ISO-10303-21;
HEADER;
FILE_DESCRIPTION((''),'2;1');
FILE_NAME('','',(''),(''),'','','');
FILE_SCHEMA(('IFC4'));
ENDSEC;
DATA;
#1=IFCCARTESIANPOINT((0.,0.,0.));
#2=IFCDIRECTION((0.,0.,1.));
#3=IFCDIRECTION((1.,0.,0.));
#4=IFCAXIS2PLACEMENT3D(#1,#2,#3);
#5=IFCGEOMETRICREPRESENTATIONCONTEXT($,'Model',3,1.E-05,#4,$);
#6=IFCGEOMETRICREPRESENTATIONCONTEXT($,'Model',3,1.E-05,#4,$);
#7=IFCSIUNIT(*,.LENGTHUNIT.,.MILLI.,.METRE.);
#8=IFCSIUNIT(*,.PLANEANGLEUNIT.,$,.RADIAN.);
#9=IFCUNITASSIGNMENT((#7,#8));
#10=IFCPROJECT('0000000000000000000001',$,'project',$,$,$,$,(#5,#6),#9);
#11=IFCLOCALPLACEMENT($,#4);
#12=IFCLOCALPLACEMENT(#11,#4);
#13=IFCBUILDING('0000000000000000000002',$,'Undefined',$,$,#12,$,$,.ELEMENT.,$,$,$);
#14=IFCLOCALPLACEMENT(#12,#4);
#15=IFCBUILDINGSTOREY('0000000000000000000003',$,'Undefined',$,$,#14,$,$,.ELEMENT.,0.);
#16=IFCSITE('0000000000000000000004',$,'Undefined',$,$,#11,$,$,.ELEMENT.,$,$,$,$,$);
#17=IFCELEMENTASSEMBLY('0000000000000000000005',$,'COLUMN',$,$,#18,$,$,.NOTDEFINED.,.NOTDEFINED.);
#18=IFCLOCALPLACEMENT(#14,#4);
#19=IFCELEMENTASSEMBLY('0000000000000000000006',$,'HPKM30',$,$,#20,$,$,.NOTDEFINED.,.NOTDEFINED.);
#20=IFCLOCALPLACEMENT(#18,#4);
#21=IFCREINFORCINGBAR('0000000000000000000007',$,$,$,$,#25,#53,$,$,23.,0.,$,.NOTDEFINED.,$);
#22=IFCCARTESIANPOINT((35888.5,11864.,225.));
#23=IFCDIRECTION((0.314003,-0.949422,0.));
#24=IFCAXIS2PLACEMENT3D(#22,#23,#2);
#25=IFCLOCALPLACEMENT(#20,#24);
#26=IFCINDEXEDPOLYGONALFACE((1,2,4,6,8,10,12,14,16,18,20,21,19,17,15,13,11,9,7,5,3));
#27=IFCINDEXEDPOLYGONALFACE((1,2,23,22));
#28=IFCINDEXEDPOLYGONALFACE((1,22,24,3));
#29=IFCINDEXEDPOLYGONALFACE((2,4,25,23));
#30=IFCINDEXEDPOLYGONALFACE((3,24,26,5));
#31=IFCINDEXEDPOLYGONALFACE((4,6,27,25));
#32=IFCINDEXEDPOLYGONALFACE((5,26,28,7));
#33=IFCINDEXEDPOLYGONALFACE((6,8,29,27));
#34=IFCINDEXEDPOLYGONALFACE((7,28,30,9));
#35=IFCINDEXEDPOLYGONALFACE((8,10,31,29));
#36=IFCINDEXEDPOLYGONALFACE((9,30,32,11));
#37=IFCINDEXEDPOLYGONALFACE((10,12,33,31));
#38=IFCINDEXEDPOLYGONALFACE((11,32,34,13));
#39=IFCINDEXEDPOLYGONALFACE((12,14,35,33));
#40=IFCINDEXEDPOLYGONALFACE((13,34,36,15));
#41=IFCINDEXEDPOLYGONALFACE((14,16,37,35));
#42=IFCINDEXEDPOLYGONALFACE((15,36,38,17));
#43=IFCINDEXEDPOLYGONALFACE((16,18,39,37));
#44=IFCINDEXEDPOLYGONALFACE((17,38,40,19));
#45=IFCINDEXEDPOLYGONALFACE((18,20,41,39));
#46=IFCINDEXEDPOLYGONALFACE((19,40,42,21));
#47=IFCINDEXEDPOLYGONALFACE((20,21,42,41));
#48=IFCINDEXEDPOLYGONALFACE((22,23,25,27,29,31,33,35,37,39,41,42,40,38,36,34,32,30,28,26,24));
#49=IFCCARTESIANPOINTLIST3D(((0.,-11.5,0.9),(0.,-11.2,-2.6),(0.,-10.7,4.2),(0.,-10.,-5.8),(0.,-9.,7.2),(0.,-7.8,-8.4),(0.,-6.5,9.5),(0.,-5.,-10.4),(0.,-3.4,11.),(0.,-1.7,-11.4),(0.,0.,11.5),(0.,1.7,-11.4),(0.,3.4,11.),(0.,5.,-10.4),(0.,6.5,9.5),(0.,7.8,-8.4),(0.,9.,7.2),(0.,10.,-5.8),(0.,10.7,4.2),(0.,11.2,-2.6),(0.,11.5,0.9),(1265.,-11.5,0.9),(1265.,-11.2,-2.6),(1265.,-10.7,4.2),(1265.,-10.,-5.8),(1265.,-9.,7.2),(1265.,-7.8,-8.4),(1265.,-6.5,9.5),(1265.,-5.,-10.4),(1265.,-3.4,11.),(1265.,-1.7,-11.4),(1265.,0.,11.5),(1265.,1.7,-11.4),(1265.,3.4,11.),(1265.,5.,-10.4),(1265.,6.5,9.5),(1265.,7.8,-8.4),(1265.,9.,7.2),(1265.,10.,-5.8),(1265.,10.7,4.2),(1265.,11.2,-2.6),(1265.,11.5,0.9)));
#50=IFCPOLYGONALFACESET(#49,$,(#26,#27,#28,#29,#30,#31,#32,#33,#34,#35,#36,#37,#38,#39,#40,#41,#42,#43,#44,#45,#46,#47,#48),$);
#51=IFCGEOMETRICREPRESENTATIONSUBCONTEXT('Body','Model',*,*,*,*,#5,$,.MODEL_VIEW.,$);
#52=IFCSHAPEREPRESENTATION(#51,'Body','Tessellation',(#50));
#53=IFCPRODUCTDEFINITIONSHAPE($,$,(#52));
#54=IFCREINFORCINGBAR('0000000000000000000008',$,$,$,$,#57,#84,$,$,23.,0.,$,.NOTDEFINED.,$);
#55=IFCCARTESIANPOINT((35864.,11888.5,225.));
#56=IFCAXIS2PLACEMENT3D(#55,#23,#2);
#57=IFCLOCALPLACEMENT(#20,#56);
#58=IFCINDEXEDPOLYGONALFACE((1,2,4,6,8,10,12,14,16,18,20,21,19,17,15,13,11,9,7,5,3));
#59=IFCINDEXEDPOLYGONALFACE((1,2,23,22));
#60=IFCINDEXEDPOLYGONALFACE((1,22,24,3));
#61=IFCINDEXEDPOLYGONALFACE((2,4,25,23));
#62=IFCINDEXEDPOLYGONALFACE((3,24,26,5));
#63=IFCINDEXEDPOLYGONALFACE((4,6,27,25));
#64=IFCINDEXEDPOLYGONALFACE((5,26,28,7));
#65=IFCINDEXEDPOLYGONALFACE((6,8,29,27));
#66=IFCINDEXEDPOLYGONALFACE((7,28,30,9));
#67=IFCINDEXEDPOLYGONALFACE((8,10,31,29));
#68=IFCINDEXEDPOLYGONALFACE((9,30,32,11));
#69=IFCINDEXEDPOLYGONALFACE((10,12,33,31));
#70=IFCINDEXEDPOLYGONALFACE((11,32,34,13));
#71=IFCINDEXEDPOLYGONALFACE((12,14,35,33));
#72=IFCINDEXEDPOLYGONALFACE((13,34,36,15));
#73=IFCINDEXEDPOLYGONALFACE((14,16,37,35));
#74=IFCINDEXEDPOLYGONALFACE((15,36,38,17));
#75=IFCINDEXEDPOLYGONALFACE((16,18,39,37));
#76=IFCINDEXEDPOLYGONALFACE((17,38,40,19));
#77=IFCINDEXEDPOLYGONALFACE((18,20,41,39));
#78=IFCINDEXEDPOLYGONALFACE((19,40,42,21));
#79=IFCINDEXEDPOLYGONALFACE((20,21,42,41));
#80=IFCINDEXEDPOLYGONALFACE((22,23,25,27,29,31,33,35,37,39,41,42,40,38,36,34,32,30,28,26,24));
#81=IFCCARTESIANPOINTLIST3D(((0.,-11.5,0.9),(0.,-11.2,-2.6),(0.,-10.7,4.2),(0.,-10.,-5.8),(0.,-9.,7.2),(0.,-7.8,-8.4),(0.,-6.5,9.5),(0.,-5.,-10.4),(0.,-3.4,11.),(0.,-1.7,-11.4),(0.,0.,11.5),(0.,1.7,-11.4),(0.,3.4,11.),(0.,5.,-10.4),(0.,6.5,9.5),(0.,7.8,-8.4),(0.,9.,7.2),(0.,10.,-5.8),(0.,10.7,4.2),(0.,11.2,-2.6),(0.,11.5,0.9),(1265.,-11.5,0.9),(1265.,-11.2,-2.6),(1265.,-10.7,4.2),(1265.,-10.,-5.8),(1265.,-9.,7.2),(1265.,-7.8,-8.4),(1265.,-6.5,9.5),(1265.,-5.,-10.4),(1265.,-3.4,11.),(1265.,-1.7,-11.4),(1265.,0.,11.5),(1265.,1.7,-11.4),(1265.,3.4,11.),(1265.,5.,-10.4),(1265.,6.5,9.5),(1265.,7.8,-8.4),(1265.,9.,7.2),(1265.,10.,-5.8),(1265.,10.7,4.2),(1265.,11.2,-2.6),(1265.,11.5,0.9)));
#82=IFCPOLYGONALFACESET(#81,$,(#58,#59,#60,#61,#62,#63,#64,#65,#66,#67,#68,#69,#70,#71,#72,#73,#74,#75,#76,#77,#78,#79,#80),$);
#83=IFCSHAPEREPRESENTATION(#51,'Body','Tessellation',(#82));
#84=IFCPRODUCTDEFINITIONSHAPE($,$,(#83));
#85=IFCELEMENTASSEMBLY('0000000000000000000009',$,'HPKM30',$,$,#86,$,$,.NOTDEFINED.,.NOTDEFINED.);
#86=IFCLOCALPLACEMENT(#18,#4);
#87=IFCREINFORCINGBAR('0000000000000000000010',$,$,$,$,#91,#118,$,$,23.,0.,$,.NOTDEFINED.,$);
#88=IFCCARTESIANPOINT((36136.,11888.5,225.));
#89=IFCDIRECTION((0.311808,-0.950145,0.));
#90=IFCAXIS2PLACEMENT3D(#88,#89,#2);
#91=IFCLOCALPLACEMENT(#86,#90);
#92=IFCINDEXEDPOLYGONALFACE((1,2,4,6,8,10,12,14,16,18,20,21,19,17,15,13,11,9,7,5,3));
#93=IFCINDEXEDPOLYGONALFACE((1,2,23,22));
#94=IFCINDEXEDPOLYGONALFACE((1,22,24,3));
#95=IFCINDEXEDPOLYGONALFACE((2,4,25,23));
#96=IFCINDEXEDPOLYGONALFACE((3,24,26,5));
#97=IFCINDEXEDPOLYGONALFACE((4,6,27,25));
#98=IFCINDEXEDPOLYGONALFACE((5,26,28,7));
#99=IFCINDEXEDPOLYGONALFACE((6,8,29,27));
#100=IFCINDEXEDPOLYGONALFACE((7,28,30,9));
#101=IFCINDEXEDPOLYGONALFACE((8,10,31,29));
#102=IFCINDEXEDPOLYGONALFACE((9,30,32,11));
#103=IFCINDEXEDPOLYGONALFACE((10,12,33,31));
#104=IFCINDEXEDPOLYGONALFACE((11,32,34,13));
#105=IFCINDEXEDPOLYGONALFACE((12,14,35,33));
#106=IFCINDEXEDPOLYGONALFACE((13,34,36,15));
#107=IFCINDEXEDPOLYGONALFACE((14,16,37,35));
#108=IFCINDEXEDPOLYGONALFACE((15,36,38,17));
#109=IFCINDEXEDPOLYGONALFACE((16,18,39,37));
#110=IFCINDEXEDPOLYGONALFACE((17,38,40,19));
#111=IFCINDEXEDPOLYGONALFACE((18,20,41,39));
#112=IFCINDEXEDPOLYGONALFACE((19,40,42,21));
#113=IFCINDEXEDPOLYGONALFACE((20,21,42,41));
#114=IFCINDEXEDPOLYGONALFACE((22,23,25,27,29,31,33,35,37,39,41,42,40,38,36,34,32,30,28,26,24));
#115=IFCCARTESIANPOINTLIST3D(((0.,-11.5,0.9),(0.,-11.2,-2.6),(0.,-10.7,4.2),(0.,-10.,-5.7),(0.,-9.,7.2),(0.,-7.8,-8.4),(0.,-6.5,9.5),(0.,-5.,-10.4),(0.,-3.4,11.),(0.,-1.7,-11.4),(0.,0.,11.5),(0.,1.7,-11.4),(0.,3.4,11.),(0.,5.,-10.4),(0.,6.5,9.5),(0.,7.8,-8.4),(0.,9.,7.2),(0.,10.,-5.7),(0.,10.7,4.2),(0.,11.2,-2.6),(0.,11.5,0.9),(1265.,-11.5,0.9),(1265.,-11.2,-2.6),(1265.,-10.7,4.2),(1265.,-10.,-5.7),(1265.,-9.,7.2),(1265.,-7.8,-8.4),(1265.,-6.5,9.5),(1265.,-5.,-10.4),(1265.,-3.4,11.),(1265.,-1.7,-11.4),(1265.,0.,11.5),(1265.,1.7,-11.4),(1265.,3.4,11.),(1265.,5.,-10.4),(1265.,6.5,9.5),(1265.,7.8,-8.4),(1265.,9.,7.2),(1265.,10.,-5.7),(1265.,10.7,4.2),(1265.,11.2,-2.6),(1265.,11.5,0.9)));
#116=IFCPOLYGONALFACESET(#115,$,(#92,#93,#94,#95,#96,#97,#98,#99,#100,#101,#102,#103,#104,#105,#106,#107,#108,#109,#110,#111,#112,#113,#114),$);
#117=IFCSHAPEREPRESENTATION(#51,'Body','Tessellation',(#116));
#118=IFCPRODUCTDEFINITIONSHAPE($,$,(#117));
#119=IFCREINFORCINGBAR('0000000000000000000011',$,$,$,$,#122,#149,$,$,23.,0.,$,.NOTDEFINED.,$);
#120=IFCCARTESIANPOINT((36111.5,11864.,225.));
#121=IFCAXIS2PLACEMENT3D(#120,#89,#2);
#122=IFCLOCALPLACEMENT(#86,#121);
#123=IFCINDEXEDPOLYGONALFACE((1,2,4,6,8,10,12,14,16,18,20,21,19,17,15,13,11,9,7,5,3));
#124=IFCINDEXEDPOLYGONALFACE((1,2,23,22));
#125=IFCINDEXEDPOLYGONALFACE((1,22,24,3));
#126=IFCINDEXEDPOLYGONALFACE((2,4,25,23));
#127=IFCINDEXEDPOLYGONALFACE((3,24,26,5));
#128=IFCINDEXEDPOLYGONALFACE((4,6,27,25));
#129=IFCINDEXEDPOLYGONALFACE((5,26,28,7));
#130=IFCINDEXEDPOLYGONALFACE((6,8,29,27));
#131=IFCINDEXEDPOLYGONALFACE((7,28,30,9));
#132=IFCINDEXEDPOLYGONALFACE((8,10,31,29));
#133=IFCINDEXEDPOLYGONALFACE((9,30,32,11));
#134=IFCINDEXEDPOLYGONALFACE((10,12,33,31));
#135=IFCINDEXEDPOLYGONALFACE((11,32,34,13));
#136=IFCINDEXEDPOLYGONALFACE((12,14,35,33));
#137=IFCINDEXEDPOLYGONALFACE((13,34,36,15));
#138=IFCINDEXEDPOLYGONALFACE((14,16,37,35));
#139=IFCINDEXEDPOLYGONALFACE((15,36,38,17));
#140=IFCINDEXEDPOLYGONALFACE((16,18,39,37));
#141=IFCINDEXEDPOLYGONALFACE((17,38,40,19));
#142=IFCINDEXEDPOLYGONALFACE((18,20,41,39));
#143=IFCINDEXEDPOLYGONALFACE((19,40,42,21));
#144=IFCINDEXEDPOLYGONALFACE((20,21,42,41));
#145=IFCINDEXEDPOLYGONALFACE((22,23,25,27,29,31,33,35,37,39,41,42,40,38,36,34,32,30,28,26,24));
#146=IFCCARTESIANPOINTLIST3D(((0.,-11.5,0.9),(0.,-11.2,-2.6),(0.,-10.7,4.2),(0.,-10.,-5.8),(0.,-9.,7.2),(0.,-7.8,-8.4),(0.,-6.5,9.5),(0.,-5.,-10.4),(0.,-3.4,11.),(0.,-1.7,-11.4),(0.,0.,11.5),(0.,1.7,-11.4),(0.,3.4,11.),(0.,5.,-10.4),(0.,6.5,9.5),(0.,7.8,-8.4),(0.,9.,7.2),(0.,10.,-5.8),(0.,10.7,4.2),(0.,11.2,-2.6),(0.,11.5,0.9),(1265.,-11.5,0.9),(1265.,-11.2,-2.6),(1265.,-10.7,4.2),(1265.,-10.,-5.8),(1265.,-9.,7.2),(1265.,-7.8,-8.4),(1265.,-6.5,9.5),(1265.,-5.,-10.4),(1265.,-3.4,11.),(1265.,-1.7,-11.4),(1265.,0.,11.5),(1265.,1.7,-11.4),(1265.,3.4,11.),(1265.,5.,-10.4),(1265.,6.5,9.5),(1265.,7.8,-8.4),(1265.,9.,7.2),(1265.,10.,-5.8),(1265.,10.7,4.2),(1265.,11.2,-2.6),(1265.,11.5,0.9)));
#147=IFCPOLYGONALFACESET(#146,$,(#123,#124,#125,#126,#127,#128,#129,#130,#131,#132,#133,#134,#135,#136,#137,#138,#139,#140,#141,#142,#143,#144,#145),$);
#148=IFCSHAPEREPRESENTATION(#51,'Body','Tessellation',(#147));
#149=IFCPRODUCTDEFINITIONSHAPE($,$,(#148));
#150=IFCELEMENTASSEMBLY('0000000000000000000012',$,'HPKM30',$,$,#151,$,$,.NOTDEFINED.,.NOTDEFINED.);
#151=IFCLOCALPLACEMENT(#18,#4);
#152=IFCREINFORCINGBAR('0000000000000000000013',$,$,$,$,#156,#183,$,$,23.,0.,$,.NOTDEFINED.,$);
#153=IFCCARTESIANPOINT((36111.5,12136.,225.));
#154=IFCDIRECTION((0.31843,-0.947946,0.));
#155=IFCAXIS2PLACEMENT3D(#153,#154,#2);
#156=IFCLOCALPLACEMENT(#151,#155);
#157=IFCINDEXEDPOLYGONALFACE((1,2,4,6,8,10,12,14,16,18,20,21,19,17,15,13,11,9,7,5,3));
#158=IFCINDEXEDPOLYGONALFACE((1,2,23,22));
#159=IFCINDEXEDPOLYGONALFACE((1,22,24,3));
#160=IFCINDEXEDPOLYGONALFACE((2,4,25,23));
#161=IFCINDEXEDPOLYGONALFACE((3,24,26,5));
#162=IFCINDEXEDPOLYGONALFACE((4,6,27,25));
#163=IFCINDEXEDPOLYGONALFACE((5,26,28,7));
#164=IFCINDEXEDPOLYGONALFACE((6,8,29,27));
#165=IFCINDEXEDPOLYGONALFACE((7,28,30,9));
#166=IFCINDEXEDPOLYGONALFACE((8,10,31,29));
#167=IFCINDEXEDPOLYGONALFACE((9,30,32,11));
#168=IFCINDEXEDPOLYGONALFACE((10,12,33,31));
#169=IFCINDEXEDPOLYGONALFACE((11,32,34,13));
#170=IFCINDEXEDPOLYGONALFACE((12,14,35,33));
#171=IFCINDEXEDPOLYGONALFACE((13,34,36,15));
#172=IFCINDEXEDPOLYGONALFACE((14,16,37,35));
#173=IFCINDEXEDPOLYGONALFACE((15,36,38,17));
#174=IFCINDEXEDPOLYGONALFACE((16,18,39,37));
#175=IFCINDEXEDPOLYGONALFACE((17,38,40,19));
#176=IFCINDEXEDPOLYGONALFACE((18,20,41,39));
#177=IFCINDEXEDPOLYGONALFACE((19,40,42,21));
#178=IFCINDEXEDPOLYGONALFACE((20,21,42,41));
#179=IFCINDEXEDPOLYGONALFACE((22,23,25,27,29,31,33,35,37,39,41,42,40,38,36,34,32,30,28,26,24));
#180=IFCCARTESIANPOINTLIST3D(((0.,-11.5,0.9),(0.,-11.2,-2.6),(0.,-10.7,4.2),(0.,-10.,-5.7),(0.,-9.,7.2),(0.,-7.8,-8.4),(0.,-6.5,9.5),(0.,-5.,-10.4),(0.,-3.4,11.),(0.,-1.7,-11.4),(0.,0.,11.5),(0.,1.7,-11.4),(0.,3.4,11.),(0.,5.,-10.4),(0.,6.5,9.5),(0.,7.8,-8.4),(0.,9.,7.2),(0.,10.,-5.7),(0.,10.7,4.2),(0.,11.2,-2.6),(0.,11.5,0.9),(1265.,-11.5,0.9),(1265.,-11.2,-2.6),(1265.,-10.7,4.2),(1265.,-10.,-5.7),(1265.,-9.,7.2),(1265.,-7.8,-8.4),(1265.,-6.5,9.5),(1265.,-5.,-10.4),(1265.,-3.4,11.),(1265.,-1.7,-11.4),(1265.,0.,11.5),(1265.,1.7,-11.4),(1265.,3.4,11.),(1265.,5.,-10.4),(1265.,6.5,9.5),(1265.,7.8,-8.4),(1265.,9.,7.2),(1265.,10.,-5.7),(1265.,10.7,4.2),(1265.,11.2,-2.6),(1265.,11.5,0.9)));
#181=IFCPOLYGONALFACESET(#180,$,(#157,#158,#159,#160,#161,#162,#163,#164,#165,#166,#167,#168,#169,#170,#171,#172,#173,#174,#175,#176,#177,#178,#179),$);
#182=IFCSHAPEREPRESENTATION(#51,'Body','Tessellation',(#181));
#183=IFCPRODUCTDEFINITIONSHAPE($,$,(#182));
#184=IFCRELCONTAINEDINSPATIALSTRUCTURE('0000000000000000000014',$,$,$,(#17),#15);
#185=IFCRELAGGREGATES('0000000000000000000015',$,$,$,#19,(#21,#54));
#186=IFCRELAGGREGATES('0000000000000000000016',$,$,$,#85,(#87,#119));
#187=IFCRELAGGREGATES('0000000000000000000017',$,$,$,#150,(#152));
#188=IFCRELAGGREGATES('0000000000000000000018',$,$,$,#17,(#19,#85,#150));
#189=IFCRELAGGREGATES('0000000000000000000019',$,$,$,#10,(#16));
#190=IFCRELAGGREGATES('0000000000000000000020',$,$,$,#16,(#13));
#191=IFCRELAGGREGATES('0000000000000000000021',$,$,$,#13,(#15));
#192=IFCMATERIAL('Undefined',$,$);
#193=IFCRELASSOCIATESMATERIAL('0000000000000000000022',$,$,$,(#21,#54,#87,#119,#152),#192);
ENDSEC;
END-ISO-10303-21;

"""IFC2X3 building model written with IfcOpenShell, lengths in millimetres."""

from ifc_helpers import new_model, entity, si_unit, frame, origin_with_axes, place, context, subcontext, project, spatial, source, transform, mapped, material, element, aggregate, save


model = new_model("IFC2X3")

# Units and contexts
model_context_1 = context("Model", 3, precision=1e-05, world=origin_with_axes())
model_context_2 = context("Model", 3, precision=1e-05, world=origin_with_axes())
body_context = subcontext(model_context_1, "Body", "Model", "MODEL_VIEW")
ifc_project = project(units=[si_unit("LENGTHUNIT", "METRE", prefix="MILLI"), si_unit("PLANEANGLEUNIT", "RADIAN")], contexts=[model_context_1, model_context_2])

# Site, building, storey
site_placement = place(None, origin_with_axes())
site = spatial("IfcSite", under=ifc_project, at=site_placement, Name="Undefined", CompositionType="ELEMENT")
building_placement = place(site_placement, origin_with_axes())
building = spatial("IfcBuilding", under=site, at=building_placement, Name="Undefined", CompositionType="ELEMENT")
storey_placement = place(building_placement, origin_with_axes())
storey = spatial("IfcBuildingStorey", under=building, at=storey_placement, Name="Undefined", CompositionType="ELEMENT", Elevation=0.0)

# Element assembly
assembly_1_placement = place(storey_placement, origin_with_axes())
assembly_1 = element("IfcElementAssembly", 1, at=assembly_1_placement, inside=storey, Name="COLUMN", AssemblyPlace="NOTDEFINED", PredefinedType="NOTDEFINED")
ifc_material_1 = material(Name="Undefined")

# Element assemblies, reinforcing bars
assembly_2_placement = place(assembly_1_placement, origin_with_axes())
assembly_2 = element("IfcElementAssembly", 2, at=assembly_2_placement, Name="HPKM30", AssemblyPlace="NOTDEFINED", PredefinedType="NOTDEFINED")
shared_shape_1 = source(origin_with_axes(), body_context, "Body", "AdvancedSweptSolid", [
    entity("IfcSweptDiskSolid", entity("IfcTrimmedCurve", entity("IfcLine", entity("IfcCartesianPoint", [0.0, 0.0, 0.0]), entity("IfcVector", entity("IfcDirection", [1.0, 0.0, 0.0]), 1.0)), [entity("IfcParameterValue", 0.0)], [entity("IfcParameterValue", 1265.0)], True, "PARAMETER"), 11.5, None, 0.0, 1265.0),
])
reinforcing_bar_1_placement = place(assembly_2_placement, frame((35888.5, 11864.0, 225.0), z_axis=(0.314003, -0.949422, 0.0), x_axis=(0.0, 0.0, 1.0)))
reinforcing_bar_1 = element("IfcReinforcingBar", 3, at=reinforcing_bar_1_placement, material=ifc_material_1, BarRole="NOTDEFINED", CrossSectionArea=0.0, NominalDiameter=23.0, context=body_context, shape_type="MappedRepresentation", body=[
    mapped(shared_shape_1, transform((0.0, 0.0, 0.0))),
])
shared_shape_2 = source(origin_with_axes(), body_context, "Body", "AdvancedSweptSolid", [
    entity("IfcSweptDiskSolid", entity("IfcTrimmedCurve", entity("IfcLine", entity("IfcCartesianPoint", [0.0, 0.0, 0.0]), entity("IfcVector", entity("IfcDirection", [1.0, 0.0, 0.0]), 1.0)), [entity("IfcParameterValue", 0.0)], [entity("IfcParameterValue", 1265.0)], True, "PARAMETER"), 11.5, None, 0.0, 1265.0),
])
reinforcing_bar_2_placement = place(assembly_2_placement, frame((35864.0, 11888.5, 225.0), z_axis=(0.314003, -0.949422, 0.0), x_axis=(0.0, 0.0, 1.0)))
reinforcing_bar_2 = element("IfcReinforcingBar", 4, at=reinforcing_bar_2_placement, material=ifc_material_1, BarRole="NOTDEFINED", CrossSectionArea=0.0, NominalDiameter=23.0, context=body_context, shape_type="MappedRepresentation", body=[
    mapped(shared_shape_2, transform((0.0, 0.0, 0.0))),
])
aggregate(assembly_2, [reinforcing_bar_1, reinforcing_bar_2])
assembly_3_placement = place(assembly_1_placement, origin_with_axes())
assembly_3 = element("IfcElementAssembly", 5, at=assembly_3_placement, Name="HPKM30", AssemblyPlace="NOTDEFINED", PredefinedType="NOTDEFINED")
shared_shape_3 = source(origin_with_axes(), body_context, "Body", "AdvancedSweptSolid", [
    entity("IfcSweptDiskSolid", entity("IfcTrimmedCurve", entity("IfcLine", entity("IfcCartesianPoint", [0.0, 0.0, 0.0]), entity("IfcVector", entity("IfcDirection", [1.0, 0.0, 0.0]), 1.0)), [entity("IfcParameterValue", 0.0)], [entity("IfcParameterValue", 1265.0)], True, "PARAMETER"), 11.5, None, 0.0, 1265.0),
])
reinforcing_bar_3_placement = place(assembly_3_placement, frame((36136.0, 11888.5, 225.0), z_axis=(0.311808, -0.950145, 0.0), x_axis=(0.0, 0.0, 1.0)))
reinforcing_bar_3 = element("IfcReinforcingBar", 6, at=reinforcing_bar_3_placement, material=ifc_material_1, BarRole="NOTDEFINED", CrossSectionArea=0.0, NominalDiameter=23.0, context=body_context, shape_type="MappedRepresentation", body=[
    mapped(shared_shape_3, transform((0.0, 0.0, 0.0))),
])
shared_shape_4 = source(origin_with_axes(), body_context, "Body", "AdvancedSweptSolid", [
    entity("IfcSweptDiskSolid", entity("IfcTrimmedCurve", entity("IfcLine", entity("IfcCartesianPoint", [0.0, 0.0, 0.0]), entity("IfcVector", entity("IfcDirection", [1.0, 0.0, 0.0]), 1.0)), [entity("IfcParameterValue", 0.0)], [entity("IfcParameterValue", 1265.0)], True, "PARAMETER"), 11.5, None, 0.0, 1265.0),
])
reinforcing_bar_4_placement = place(assembly_3_placement, frame((36111.5, 11864.0, 225.0), z_axis=(0.311808, -0.950145, 0.0), x_axis=(0.0, 0.0, 1.0)))
reinforcing_bar_4 = element("IfcReinforcingBar", 7, at=reinforcing_bar_4_placement, material=ifc_material_1, BarRole="NOTDEFINED", CrossSectionArea=0.0, NominalDiameter=23.0, context=body_context, shape_type="MappedRepresentation", body=[
    mapped(shared_shape_4, transform((0.0, 0.0, 0.0))),
])
aggregate(assembly_3, [reinforcing_bar_3, reinforcing_bar_4])
assembly_4_placement = place(assembly_1_placement, origin_with_axes())
assembly_4 = element("IfcElementAssembly", 8, at=assembly_4_placement, Name="HPKM30", AssemblyPlace="NOTDEFINED", PredefinedType="NOTDEFINED")
shared_shape_5 = source(origin_with_axes(), body_context, "Body", "AdvancedSweptSolid", [
    entity("IfcSweptDiskSolid", entity("IfcTrimmedCurve", entity("IfcLine", entity("IfcCartesianPoint", [0.0, 0.0, 0.0]), entity("IfcVector", entity("IfcDirection", [1.0, 0.0, 0.0]), 1.0)), [entity("IfcParameterValue", 0.0)], [entity("IfcParameterValue", 1265.0)], True, "PARAMETER"), 11.5, None, 0.0, 1265.0),
])
reinforcing_bar_5_placement = place(assembly_4_placement, frame((36111.5, 12136.0, 225.0), z_axis=(0.31843, -0.947946, 0.0), x_axis=(0.0, 0.0, 1.0)))
reinforcing_bar_5 = element("IfcReinforcingBar", 9, at=reinforcing_bar_5_placement, material=ifc_material_1, BarRole="NOTDEFINED", CrossSectionArea=0.0, NominalDiameter=23.0, context=body_context, shape_type="MappedRepresentation", body=[
    mapped(shared_shape_5, transform((0.0, 0.0, 0.0))),
])
aggregate(assembly_4, [reinforcing_bar_5])

aggregate(assembly_1, [assembly_2, assembly_3, assembly_4])

save(model, "model.ifc")
